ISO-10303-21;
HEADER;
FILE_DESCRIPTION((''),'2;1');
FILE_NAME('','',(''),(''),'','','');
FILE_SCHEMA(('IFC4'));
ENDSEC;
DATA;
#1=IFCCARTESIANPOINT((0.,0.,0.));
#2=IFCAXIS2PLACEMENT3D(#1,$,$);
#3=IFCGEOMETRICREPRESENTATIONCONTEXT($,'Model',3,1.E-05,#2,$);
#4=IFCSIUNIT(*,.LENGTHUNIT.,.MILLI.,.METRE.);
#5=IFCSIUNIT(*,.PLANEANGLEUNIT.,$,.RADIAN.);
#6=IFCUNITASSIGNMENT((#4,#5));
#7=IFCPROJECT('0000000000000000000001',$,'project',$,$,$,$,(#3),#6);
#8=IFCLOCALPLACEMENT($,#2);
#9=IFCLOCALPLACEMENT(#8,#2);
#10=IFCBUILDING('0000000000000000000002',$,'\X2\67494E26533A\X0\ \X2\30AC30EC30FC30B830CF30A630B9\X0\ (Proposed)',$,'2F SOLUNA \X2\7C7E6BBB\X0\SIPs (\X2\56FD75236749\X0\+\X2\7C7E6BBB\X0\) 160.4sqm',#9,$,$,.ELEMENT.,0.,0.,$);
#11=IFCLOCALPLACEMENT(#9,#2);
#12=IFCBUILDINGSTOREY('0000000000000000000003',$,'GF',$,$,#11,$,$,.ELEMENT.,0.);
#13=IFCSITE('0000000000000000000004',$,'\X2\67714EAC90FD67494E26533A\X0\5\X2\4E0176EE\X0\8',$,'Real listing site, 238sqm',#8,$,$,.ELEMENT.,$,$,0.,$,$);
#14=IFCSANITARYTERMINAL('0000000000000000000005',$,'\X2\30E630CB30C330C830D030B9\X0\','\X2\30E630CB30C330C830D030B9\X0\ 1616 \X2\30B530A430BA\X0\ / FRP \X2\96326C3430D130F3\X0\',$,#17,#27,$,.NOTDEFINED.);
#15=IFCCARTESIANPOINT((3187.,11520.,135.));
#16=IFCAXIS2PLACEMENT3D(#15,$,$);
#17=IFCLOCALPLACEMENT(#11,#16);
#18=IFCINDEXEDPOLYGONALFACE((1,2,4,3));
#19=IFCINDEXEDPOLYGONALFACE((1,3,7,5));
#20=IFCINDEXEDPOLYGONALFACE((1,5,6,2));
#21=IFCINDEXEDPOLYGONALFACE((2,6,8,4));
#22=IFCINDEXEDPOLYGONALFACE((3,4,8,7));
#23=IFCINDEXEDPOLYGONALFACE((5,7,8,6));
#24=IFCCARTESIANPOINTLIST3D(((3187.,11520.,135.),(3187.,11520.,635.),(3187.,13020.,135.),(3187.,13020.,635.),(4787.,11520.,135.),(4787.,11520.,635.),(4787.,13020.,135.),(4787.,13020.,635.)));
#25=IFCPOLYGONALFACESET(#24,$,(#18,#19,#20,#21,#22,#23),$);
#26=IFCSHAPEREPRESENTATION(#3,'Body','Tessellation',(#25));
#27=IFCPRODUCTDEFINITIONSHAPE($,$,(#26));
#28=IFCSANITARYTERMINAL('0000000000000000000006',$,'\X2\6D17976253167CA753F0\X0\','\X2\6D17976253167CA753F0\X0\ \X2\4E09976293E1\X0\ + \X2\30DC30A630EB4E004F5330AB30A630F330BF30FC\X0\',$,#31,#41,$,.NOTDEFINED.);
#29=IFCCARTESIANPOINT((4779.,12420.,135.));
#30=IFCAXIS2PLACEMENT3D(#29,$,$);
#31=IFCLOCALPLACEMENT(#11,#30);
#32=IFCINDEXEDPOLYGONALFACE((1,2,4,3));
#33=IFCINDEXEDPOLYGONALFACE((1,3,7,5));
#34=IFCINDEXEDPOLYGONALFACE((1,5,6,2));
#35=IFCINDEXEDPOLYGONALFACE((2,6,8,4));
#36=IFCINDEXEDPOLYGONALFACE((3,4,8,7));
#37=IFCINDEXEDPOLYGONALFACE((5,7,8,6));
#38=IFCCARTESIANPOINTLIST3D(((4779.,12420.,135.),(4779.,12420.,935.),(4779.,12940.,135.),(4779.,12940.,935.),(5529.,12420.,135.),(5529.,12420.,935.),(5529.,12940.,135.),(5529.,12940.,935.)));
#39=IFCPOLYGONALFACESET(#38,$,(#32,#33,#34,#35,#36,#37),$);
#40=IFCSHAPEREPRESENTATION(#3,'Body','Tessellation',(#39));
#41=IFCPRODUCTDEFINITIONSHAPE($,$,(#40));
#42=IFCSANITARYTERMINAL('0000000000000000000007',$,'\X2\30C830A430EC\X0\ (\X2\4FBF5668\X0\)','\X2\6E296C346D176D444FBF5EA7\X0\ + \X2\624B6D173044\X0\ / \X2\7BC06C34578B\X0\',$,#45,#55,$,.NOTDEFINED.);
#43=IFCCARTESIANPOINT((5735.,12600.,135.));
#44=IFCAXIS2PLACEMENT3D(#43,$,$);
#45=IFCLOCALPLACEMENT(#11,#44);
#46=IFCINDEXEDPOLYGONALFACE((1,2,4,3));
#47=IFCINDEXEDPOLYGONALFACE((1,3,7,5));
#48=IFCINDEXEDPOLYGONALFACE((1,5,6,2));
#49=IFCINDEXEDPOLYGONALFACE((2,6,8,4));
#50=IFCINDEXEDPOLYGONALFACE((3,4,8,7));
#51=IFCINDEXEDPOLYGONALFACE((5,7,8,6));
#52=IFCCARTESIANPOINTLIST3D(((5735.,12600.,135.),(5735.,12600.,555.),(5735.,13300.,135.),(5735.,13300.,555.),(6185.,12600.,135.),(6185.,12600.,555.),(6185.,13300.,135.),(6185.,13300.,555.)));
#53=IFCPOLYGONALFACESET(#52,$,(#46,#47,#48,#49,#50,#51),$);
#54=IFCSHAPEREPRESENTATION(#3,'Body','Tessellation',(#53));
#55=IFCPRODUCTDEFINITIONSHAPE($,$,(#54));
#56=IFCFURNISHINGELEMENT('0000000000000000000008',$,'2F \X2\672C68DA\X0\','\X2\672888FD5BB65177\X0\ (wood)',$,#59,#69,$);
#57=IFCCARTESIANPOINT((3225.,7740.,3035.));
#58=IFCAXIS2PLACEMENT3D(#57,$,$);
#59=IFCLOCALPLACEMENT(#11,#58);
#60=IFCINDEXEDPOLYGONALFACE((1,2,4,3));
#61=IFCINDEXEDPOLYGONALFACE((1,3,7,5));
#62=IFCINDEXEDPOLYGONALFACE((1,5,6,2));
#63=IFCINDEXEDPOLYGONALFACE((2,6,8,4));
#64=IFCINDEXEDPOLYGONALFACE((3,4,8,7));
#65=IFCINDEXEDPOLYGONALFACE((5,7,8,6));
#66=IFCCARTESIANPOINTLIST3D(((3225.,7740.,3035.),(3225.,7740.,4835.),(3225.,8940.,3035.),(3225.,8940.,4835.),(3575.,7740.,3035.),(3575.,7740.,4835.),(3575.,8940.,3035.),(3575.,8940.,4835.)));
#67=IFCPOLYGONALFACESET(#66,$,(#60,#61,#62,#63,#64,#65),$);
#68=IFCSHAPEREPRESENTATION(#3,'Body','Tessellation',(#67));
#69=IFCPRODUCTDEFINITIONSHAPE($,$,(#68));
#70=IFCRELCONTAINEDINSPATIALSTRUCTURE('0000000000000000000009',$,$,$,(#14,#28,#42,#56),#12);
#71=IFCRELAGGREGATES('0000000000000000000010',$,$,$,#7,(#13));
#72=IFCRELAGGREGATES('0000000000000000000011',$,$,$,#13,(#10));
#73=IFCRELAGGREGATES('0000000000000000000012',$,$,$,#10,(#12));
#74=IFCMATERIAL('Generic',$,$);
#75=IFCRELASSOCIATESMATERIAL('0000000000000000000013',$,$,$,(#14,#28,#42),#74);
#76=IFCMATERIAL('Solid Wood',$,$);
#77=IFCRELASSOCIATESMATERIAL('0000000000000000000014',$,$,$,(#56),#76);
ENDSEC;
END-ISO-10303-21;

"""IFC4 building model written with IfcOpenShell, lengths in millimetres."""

from ifc_helpers import new_model, si_unit, frame, frame_2d, origin, place, context, project, spatial, rectangle, extrude, material, element, save


model = new_model("IFC4")

# Units and contexts
model_context = context("Model", 3, precision=1e-05, world=origin())
ifc_project = project(units=[si_unit("LENGTHUNIT", "METRE", prefix="MILLI"), si_unit("PLANEANGLEUNIT", "RADIAN")], contexts=[model_context])

# Site, building, storey
site_placement = place(None, origin())
site = spatial("IfcSite", under=ifc_project, at=site_placement, Name="東京都杉並区5丁目8", ObjectType="Real listing site, 238sqm", CompositionType="ELEMENT", RefElevation=0.0)
building_placement = place(site_placement, origin())
building = spatial("IfcBuilding", under=site, at=building_placement, Name="杉並区 ガレージハウス (Proposed)", ObjectType="2F SOLUNA 籾殻SIPs (国産杉+籾殻) 160.4sqm", CompositionType="ELEMENT", ElevationOfRefHeight=0.0, ElevationOfTerrain=0.0)
storey_placement = place(building_placement, origin())
storey = spatial("IfcBuildingStorey", under=building, at=storey_placement, Name="GF", CompositionType="ELEMENT", Elevation=0.0)

# Shared definitions
ifc_material_1 = material(Name="Solid Wood")
ifc_material_2 = material(Name="Generic")

# Sanitary terminals
sanitary_terminal_1_placement = place(storey_placement, frame((3187.0, 11520.0, 135.0)))
element("IfcSanitaryTerminal", 1, at=sanitary_terminal_1_placement, inside=storey, material=ifc_material_2, Name="ユニットバス", Description="ユニットバス 1616 サイズ / FRP 防水パン", PredefinedType="NOTDEFINED", context=model_context, shape_type="SweptSolid", body=[
    extrude(rectangle(XDim=1600.0, YDim=1500.0, at=frame_2d((800.0, 750.0))), frame((3187.0, 11520.0, 135.0)), (0.0, 0.0, 1.0), 500.0),
])
sanitary_terminal_2_placement = place(storey_placement, frame((4779.0, 12420.0, 135.0)))
element("IfcSanitaryTerminal", 2, at=sanitary_terminal_2_placement, inside=storey, material=ifc_material_2, Name="洗面化粧台", Description="洗面化粧台 三面鏡 + ボウル一体カウンター", PredefinedType="NOTDEFINED", context=model_context, shape_type="SweptSolid", body=[
    extrude(rectangle(XDim=750.0, YDim=520.0, at=frame_2d((375.0, 260.0))), frame((4779.0, 12420.0, 135.0)), (0.0, 0.0, 1.0), 800.0),
])
sanitary_terminal_3_placement = place(storey_placement, frame((5735.0, 12600.0, 135.0)))
element("IfcSanitaryTerminal", 3, at=sanitary_terminal_3_placement, inside=storey, material=ifc_material_2, Name="トイレ (便器)", Description="温水洗浄便座 + 手洗い / 節水型", PredefinedType="NOTDEFINED", context=model_context, shape_type="SweptSolid", body=[
    extrude(rectangle(XDim=450.0, YDim=700.0, at=frame_2d((225.0, 350.0))), frame((5735.0, 12600.0, 135.0)), (0.0, 0.0, 1.0), 420.0),
])

# Furnishing element
furnishing_placement = place(storey_placement, frame((3225.0, 7740.0, 3035.0)))
element("IfcFurnishingElement", 4, at=furnishing_placement, inside=storey, material=ifc_material_1, Name="2F 本棚", Description="木製家具 (wood)", context=model_context, shape_type="SweptSolid", body=[
    extrude(rectangle(XDim=350.0, YDim=1200.0, at=frame_2d((175.0, 600.0))), frame((3225.0, 7740.0, 3035.0)), (0.0, 0.0, 1.0), 1800.0),
])

save(model, "model.ifc")
